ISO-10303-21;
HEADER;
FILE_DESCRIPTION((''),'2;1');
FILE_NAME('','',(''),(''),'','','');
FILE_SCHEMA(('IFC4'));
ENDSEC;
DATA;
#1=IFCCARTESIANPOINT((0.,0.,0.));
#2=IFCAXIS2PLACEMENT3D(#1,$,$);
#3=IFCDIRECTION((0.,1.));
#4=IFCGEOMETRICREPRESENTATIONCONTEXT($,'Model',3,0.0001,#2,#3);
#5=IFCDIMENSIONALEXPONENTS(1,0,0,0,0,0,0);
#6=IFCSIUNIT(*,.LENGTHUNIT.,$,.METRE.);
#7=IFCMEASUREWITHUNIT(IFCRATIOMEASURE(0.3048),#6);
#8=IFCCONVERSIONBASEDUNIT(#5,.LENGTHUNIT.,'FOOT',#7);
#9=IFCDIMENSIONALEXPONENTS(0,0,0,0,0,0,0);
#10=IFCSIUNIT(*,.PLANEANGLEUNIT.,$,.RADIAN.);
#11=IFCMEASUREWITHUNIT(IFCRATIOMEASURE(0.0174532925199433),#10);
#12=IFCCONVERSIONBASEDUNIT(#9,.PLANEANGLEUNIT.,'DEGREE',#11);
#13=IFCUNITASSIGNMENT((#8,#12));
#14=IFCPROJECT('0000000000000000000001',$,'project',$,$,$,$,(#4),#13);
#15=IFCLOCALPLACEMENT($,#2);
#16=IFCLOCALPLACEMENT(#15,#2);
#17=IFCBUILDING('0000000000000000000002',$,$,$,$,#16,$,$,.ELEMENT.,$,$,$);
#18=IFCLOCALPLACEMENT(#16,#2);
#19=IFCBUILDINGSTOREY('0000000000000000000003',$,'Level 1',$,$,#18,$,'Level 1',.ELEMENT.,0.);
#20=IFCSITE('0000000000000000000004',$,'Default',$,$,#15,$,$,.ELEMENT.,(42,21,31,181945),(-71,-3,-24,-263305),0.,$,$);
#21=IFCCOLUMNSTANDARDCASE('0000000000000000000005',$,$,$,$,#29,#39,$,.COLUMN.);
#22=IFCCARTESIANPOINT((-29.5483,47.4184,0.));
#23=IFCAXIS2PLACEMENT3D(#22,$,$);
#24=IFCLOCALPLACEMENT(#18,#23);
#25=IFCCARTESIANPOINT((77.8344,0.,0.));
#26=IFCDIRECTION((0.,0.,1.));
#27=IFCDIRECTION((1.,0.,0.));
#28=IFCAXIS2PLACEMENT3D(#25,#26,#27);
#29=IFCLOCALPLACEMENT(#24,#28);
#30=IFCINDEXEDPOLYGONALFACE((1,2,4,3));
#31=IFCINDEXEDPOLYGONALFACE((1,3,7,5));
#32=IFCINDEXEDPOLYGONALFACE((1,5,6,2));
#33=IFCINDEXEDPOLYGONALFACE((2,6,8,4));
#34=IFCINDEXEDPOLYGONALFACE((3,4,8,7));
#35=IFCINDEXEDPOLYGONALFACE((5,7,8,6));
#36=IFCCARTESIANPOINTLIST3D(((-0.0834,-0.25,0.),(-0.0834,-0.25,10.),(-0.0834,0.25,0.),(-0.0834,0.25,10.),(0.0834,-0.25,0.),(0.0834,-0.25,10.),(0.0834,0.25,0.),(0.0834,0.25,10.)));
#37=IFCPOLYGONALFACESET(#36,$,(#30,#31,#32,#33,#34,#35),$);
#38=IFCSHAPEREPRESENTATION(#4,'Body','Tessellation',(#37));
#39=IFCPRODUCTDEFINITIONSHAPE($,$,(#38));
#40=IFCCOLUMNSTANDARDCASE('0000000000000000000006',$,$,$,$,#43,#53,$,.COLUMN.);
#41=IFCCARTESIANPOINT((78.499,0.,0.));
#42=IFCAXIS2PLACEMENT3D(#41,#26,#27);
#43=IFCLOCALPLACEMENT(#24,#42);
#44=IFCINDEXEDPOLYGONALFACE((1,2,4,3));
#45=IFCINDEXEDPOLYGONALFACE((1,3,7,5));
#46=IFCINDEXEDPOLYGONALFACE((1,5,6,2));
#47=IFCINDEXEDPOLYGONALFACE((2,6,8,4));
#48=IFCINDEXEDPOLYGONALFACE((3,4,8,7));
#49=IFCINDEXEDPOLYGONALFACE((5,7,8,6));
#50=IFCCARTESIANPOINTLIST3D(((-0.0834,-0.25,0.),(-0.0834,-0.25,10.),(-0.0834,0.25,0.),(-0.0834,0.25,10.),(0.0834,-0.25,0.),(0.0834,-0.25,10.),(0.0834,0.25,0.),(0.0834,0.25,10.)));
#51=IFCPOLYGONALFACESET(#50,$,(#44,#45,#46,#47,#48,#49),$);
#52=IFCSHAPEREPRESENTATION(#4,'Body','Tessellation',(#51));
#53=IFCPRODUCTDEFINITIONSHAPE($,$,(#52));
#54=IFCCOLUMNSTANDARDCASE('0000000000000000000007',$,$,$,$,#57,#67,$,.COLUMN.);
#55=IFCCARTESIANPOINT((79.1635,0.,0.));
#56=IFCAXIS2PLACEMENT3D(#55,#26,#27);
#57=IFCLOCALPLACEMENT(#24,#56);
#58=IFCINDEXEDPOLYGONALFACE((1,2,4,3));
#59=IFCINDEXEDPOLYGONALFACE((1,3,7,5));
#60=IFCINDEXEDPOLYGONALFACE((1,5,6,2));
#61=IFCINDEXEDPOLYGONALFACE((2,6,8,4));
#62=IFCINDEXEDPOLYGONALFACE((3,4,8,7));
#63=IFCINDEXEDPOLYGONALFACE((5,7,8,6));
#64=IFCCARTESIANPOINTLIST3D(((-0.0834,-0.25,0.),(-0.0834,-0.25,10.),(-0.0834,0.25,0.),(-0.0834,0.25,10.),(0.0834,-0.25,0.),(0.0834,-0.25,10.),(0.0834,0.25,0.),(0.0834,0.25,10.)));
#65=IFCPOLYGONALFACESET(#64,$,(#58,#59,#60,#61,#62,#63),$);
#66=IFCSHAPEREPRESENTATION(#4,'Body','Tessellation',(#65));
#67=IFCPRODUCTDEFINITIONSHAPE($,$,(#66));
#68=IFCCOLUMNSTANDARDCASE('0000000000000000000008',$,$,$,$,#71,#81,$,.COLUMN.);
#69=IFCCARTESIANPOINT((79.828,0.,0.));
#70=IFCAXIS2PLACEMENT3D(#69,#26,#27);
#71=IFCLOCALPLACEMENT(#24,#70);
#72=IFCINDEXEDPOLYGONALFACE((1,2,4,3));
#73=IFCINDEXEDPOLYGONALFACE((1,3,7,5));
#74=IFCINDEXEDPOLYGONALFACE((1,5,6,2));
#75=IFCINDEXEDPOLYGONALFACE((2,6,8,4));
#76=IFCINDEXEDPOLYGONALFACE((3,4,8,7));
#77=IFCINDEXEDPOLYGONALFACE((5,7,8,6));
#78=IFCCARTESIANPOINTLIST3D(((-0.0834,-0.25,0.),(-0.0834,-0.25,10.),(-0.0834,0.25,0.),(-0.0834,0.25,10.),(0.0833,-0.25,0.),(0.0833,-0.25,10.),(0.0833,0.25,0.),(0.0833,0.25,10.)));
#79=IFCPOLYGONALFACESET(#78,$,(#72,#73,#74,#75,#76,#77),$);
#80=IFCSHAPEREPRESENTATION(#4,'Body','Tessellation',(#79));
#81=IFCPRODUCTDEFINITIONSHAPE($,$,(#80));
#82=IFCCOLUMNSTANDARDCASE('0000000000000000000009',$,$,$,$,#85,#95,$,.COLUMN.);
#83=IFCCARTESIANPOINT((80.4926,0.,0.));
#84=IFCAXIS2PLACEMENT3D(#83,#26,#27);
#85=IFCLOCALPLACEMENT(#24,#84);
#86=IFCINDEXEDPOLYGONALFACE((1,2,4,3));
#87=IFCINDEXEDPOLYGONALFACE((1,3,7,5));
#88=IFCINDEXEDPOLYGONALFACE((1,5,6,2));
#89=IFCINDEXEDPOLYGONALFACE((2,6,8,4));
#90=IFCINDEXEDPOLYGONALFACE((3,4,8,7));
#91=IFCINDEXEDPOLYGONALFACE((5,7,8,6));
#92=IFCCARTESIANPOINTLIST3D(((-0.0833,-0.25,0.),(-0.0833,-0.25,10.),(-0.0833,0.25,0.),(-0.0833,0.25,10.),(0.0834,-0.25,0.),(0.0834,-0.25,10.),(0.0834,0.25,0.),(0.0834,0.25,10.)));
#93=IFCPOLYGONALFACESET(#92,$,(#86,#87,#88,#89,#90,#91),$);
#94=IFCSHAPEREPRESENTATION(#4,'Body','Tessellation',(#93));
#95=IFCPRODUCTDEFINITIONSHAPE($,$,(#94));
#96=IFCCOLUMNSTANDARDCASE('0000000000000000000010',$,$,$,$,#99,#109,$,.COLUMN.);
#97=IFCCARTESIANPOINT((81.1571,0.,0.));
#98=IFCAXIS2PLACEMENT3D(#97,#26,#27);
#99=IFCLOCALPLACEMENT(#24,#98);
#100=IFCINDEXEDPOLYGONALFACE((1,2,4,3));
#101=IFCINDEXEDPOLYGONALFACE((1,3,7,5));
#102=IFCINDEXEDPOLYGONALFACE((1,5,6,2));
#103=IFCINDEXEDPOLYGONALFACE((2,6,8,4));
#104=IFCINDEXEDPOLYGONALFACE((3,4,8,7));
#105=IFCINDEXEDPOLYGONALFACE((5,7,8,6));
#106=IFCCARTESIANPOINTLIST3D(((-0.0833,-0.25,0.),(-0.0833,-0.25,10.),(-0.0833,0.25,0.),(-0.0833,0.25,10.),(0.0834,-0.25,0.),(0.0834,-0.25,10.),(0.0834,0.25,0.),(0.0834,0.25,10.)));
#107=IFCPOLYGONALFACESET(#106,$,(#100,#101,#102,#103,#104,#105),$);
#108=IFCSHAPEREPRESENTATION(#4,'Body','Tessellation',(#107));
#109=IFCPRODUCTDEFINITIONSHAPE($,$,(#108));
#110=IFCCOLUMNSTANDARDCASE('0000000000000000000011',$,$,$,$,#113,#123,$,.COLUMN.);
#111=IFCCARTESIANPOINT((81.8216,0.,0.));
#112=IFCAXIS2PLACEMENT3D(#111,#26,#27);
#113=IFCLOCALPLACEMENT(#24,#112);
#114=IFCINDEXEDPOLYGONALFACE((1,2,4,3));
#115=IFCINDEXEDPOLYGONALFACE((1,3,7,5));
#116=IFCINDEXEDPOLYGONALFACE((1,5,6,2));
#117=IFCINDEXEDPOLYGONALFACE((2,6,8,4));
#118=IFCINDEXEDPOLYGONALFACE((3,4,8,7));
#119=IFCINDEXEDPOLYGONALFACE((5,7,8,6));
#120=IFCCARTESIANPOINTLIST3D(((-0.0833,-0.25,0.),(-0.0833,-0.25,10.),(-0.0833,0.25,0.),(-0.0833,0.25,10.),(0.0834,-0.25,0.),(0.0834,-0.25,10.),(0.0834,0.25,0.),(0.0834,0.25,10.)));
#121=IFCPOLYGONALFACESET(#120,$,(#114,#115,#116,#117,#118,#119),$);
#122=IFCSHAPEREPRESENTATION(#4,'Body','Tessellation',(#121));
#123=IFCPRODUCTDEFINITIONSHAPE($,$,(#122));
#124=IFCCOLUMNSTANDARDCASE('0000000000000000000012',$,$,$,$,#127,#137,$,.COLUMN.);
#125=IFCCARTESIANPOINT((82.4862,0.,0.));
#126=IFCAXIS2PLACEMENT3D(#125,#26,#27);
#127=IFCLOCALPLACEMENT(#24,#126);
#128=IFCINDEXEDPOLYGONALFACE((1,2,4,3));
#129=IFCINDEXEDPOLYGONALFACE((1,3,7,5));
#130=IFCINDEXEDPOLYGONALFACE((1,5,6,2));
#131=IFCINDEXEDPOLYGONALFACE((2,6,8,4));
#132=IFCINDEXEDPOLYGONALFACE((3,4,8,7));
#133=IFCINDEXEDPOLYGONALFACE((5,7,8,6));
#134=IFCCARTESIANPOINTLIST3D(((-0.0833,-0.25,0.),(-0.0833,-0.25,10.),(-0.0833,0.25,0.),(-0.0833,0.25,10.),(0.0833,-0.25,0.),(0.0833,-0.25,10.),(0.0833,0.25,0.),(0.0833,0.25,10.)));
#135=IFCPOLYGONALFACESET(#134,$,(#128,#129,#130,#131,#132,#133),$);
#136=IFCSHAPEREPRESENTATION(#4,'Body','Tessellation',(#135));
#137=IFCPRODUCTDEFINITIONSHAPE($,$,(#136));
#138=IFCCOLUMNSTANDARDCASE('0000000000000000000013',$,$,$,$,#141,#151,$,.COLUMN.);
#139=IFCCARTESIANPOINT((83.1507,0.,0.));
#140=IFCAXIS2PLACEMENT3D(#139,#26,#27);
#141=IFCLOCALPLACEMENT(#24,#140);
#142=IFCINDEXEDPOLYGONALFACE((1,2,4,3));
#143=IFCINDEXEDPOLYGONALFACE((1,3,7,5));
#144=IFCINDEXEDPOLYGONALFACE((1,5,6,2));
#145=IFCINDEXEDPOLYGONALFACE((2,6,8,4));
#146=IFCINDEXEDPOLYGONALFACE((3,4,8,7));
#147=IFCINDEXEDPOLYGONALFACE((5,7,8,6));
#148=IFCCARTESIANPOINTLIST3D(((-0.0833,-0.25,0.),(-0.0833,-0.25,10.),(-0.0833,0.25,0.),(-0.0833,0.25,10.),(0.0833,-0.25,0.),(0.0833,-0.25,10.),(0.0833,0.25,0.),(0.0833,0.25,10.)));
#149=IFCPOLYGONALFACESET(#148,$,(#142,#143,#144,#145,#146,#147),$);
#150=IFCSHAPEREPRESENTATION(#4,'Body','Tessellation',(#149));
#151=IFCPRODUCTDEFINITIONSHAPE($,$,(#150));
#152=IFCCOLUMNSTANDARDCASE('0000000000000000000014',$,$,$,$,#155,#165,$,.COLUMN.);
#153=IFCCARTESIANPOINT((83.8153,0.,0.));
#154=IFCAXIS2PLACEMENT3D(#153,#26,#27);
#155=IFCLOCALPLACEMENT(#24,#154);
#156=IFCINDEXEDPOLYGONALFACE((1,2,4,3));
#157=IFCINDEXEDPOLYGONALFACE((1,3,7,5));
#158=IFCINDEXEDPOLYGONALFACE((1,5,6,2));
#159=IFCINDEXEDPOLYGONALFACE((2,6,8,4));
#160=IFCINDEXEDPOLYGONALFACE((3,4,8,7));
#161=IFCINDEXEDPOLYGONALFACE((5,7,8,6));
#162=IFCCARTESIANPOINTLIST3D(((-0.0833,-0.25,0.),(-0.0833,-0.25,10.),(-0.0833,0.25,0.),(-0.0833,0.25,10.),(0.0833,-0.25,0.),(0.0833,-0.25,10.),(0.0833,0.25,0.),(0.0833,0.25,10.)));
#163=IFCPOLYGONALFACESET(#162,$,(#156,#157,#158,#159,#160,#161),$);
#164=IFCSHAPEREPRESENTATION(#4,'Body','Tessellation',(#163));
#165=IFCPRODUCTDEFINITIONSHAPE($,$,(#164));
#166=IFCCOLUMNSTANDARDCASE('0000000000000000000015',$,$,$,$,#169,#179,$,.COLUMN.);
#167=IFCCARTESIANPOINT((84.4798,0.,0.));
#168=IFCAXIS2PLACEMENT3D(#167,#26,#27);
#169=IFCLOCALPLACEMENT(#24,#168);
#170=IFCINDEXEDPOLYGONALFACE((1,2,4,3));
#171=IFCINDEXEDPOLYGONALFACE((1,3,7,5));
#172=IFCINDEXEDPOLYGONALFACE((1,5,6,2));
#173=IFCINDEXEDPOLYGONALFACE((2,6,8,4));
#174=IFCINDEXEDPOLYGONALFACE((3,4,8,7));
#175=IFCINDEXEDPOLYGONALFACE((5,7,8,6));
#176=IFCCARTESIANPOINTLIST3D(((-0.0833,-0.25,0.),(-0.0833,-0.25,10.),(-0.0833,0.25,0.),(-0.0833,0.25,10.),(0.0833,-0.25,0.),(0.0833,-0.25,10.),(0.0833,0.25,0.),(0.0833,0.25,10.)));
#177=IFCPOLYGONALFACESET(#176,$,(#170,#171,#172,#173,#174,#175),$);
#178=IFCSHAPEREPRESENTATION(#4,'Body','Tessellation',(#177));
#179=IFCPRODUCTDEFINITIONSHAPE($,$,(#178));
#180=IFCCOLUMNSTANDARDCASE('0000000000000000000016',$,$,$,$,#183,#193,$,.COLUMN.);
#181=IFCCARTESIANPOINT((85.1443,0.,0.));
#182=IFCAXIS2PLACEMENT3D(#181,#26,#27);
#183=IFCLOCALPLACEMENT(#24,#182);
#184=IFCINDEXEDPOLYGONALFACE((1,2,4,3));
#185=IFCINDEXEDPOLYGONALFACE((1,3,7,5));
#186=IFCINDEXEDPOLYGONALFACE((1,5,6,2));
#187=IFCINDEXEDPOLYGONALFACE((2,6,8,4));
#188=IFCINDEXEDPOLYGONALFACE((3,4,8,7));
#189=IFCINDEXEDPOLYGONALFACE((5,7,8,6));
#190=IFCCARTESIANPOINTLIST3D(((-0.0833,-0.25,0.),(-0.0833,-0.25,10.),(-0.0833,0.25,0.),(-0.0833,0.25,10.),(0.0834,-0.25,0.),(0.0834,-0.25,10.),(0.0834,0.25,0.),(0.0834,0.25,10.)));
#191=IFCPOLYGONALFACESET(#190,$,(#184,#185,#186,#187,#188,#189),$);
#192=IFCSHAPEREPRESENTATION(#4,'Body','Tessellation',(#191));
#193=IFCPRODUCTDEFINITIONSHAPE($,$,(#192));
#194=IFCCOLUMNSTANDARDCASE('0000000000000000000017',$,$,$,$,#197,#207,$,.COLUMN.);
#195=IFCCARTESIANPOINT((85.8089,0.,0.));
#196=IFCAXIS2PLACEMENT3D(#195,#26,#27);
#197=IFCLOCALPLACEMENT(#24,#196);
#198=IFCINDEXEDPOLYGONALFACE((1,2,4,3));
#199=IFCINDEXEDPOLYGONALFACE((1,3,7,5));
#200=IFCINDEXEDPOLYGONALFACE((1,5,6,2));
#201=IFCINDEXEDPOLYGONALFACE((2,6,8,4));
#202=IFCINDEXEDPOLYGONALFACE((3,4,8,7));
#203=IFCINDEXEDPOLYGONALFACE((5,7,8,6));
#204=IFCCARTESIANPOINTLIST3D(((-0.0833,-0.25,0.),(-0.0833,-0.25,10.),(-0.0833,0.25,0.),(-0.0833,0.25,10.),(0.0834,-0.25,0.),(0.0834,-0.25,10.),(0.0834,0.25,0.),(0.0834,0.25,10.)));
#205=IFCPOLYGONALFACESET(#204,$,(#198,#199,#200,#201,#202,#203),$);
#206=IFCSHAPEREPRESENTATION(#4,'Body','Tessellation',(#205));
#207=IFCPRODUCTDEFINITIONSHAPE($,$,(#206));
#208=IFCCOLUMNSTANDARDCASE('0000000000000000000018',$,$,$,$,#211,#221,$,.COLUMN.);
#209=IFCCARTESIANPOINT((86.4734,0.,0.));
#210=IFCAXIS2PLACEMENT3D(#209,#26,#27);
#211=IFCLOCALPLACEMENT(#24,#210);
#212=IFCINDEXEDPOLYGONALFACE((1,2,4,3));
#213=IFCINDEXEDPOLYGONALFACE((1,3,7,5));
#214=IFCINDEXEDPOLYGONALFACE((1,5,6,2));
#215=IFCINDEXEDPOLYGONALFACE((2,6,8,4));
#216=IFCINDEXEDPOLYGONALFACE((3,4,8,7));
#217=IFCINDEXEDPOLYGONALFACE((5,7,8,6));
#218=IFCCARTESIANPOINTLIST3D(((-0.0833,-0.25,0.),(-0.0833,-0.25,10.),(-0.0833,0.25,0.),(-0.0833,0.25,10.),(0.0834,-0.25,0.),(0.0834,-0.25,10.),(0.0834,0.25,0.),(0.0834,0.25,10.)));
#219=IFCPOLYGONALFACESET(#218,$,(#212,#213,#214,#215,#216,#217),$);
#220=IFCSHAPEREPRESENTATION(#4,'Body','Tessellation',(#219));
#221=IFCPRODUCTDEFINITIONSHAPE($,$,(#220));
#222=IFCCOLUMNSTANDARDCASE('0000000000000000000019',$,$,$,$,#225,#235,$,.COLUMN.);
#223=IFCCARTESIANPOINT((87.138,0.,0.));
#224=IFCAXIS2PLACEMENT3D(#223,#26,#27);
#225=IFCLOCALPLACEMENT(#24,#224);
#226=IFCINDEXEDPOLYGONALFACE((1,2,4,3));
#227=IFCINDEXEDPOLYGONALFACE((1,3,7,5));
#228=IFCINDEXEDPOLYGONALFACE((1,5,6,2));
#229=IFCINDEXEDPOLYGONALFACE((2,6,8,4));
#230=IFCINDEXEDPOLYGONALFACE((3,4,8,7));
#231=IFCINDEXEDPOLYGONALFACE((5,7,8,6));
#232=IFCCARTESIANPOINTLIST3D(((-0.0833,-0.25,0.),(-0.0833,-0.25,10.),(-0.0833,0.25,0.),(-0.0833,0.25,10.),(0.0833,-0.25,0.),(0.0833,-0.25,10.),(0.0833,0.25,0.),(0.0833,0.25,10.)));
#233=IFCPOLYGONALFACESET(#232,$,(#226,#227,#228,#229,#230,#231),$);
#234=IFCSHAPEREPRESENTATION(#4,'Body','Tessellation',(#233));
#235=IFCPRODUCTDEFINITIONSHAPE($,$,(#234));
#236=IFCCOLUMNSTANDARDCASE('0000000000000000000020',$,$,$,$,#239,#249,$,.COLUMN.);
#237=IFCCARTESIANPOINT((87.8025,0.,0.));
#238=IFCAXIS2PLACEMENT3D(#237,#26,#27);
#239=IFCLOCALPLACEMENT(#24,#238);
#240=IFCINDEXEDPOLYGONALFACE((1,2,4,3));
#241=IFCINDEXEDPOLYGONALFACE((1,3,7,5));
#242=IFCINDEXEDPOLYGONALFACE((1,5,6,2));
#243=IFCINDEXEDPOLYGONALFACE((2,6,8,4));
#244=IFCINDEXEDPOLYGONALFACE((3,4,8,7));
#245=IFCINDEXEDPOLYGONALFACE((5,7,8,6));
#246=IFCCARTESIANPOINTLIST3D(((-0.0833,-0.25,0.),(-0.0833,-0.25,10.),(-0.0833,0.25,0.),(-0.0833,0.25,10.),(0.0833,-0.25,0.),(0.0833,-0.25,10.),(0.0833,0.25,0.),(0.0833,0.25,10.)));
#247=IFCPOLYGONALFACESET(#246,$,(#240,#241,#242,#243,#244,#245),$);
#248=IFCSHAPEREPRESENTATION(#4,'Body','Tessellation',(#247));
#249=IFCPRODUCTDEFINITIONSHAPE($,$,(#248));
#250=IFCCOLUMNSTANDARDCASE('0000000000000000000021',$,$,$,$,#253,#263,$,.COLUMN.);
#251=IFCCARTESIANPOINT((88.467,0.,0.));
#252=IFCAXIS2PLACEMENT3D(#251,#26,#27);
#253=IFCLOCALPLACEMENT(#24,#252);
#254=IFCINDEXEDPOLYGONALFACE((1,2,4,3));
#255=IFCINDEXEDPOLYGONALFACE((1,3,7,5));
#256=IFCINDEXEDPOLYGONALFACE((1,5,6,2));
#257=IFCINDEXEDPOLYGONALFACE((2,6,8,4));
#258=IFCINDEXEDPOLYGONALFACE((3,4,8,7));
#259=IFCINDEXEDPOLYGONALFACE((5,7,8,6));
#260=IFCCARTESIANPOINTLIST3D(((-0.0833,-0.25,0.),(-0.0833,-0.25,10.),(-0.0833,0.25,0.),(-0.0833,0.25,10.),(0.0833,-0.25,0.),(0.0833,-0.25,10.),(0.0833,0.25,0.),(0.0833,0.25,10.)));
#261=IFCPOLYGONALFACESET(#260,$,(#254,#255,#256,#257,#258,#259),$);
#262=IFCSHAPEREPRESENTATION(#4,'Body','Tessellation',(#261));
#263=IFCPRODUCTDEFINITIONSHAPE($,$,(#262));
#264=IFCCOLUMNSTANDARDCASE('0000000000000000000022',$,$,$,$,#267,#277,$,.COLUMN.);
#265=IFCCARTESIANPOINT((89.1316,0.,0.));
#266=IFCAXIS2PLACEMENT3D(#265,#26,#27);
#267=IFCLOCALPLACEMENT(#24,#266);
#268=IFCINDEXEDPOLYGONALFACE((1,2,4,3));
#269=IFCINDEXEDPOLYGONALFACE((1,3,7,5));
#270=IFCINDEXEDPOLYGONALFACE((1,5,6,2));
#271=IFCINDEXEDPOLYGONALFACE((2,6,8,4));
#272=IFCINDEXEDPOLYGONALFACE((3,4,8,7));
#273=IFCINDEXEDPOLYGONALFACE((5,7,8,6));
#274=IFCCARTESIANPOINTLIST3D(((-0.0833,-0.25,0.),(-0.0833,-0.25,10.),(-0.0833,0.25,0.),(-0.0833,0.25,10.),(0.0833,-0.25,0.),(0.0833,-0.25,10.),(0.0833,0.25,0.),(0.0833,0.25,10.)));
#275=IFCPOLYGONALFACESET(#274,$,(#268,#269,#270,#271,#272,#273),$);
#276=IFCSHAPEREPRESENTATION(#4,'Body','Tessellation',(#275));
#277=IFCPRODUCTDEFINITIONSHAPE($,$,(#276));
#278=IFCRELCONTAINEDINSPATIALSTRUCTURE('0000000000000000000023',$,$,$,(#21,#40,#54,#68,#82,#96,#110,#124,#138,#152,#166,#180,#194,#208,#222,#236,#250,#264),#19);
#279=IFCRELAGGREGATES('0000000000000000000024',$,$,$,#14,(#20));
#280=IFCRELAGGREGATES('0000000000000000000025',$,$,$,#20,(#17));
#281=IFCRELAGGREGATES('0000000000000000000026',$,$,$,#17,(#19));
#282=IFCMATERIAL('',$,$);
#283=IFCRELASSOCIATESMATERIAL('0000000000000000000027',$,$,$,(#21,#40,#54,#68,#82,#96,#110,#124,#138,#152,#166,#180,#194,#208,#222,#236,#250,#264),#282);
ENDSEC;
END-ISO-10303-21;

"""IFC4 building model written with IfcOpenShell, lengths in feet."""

from ifc_helpers import new_model, entity, si_unit, converted_unit, direction, frame, origin, place, context, project, spatial, rectangle, extrude, material, element, save


model = new_model("IFC4")

# Units and contexts
model_context = context("Model", 3, precision=0.0001, world=origin(), true_north=direction((0.0, 1.0)))
ifc_project = project(units=[converted_unit("LENGTHUNIT", "FOOT", entity("IfcRatioMeasure", 0.3048), si_unit("LENGTHUNIT", "METRE"), dimensions=[1, 0, 0, 0, 0, 0, 0]), converted_unit("PLANEANGLEUNIT", "DEGREE", entity("IfcRatioMeasure", 0.0174532925199433), si_unit("PLANEANGLEUNIT", "RADIAN"), dimensions=[0, 0, 0, 0, 0, 0, 0])], contexts=[model_context])

# Site, building, storey
site_placement = place(None, origin())
site = spatial("IfcSite", under=ifc_project, at=site_placement, Name="Default", CompositionType="ELEMENT", RefLatitude=(42, 21, 31, 181945), RefLongitude=(-71, -3, -24, -263305), RefElevation=0.0)
building_placement = place(site_placement, origin())
building = spatial("IfcBuilding", under=site, at=building_placement, CompositionType="ELEMENT")
storey_placement = place(building_placement, origin())
storey = spatial("IfcBuildingStorey", under=building, at=storey_placement, Name="Level 1", LongName="Level 1", CompositionType="ELEMENT", Elevation=0.0)

# Columns
ifc_material_1 = material(Name="")
placement = place(storey_placement, frame((-29.5483, 47.4184, 0.0)))
for number, where, z_axis, x_axis in (
    (1, (77.8344, 0.0, 0.0), (0.0, 0.0, 1.0), (1.0, 0.0, 0.0)),
    (2, (78.499, 0.0, 0.0), (0.0, 0.0, 1.0), (1.0, 0.0, 0.0)),
    (3, (79.1635, 0.0, 0.0), (0.0, 0.0, 1.0), (1.0, 0.0, 0.0)),
    (4, (79.828, 0.0, 0.0), (0.0, 0.0, 1.0), (1.0, 0.0, 0.0)),
    (5, (80.4926, 0.0, 0.0), (0.0, 0.0, 1.0), (1.0, 0.0, 0.0)),
    (6, (81.1571, 0.0, 0.0), (0.0, 0.0, 1.0), (1.0, 0.0, 0.0)),
    (7, (81.8216, 0.0, 0.0), (0.0, 0.0, 1.0), (1.0, 0.0, 0.0)),
    (8, (82.4862, 0.0, 0.0), (0.0, 0.0, 1.0), (1.0, 0.0, 0.0)),
    (9, (83.1507, 0.0, 0.0), (0.0, 0.0, 1.0), (1.0, 0.0, 0.0)),
    (10, (83.8153, 0.0, 0.0), (0.0, 0.0, 1.0), (1.0, 0.0, 0.0)),
    (11, (84.4798, 0.0, 0.0), (0.0, 0.0, 1.0), (1.0, 0.0, 0.0)),
    (12, (85.1443, 0.0, 0.0), (0.0, 0.0, 1.0), (1.0, 0.0, 0.0)),
    (13, (85.8089, 0.0, 0.0), (0.0, 0.0, 1.0), (1.0, 0.0, 0.0)),
    (14, (86.4734, 0.0, 0.0), (0.0, 0.0, 1.0), (1.0, 0.0, 0.0)),
    (15, (87.138, 0.0, 0.0), (0.0, 0.0, 1.0), (1.0, 0.0, 0.0)),
    (16, (87.8025, 0.0, 0.0), (0.0, 0.0, 1.0), (1.0, 0.0, 0.0)),
    (17, (88.467, 0.0, 0.0), (0.0, 0.0, 1.0), (1.0, 0.0, 0.0)),
    (18, (89.1316, 0.0, 0.0), (0.0, 0.0, 1.0), (1.0, 0.0, 0.0)),
):
    element("IfcColumnStandardCase", number, at=place(placement, frame(where, z_axis=z_axis, x_axis=x_axis)), inside=storey, material=ifc_material_1, PredefinedType="COLUMN", context=model_context, shape_type="SweptSolid", body=[
        extrude(rectangle(XDim=0.1667, YDim=0.5), origin(), (0.0, 0.0, 1.0), 10.0),
    ])

save(model, "model.ifc")
